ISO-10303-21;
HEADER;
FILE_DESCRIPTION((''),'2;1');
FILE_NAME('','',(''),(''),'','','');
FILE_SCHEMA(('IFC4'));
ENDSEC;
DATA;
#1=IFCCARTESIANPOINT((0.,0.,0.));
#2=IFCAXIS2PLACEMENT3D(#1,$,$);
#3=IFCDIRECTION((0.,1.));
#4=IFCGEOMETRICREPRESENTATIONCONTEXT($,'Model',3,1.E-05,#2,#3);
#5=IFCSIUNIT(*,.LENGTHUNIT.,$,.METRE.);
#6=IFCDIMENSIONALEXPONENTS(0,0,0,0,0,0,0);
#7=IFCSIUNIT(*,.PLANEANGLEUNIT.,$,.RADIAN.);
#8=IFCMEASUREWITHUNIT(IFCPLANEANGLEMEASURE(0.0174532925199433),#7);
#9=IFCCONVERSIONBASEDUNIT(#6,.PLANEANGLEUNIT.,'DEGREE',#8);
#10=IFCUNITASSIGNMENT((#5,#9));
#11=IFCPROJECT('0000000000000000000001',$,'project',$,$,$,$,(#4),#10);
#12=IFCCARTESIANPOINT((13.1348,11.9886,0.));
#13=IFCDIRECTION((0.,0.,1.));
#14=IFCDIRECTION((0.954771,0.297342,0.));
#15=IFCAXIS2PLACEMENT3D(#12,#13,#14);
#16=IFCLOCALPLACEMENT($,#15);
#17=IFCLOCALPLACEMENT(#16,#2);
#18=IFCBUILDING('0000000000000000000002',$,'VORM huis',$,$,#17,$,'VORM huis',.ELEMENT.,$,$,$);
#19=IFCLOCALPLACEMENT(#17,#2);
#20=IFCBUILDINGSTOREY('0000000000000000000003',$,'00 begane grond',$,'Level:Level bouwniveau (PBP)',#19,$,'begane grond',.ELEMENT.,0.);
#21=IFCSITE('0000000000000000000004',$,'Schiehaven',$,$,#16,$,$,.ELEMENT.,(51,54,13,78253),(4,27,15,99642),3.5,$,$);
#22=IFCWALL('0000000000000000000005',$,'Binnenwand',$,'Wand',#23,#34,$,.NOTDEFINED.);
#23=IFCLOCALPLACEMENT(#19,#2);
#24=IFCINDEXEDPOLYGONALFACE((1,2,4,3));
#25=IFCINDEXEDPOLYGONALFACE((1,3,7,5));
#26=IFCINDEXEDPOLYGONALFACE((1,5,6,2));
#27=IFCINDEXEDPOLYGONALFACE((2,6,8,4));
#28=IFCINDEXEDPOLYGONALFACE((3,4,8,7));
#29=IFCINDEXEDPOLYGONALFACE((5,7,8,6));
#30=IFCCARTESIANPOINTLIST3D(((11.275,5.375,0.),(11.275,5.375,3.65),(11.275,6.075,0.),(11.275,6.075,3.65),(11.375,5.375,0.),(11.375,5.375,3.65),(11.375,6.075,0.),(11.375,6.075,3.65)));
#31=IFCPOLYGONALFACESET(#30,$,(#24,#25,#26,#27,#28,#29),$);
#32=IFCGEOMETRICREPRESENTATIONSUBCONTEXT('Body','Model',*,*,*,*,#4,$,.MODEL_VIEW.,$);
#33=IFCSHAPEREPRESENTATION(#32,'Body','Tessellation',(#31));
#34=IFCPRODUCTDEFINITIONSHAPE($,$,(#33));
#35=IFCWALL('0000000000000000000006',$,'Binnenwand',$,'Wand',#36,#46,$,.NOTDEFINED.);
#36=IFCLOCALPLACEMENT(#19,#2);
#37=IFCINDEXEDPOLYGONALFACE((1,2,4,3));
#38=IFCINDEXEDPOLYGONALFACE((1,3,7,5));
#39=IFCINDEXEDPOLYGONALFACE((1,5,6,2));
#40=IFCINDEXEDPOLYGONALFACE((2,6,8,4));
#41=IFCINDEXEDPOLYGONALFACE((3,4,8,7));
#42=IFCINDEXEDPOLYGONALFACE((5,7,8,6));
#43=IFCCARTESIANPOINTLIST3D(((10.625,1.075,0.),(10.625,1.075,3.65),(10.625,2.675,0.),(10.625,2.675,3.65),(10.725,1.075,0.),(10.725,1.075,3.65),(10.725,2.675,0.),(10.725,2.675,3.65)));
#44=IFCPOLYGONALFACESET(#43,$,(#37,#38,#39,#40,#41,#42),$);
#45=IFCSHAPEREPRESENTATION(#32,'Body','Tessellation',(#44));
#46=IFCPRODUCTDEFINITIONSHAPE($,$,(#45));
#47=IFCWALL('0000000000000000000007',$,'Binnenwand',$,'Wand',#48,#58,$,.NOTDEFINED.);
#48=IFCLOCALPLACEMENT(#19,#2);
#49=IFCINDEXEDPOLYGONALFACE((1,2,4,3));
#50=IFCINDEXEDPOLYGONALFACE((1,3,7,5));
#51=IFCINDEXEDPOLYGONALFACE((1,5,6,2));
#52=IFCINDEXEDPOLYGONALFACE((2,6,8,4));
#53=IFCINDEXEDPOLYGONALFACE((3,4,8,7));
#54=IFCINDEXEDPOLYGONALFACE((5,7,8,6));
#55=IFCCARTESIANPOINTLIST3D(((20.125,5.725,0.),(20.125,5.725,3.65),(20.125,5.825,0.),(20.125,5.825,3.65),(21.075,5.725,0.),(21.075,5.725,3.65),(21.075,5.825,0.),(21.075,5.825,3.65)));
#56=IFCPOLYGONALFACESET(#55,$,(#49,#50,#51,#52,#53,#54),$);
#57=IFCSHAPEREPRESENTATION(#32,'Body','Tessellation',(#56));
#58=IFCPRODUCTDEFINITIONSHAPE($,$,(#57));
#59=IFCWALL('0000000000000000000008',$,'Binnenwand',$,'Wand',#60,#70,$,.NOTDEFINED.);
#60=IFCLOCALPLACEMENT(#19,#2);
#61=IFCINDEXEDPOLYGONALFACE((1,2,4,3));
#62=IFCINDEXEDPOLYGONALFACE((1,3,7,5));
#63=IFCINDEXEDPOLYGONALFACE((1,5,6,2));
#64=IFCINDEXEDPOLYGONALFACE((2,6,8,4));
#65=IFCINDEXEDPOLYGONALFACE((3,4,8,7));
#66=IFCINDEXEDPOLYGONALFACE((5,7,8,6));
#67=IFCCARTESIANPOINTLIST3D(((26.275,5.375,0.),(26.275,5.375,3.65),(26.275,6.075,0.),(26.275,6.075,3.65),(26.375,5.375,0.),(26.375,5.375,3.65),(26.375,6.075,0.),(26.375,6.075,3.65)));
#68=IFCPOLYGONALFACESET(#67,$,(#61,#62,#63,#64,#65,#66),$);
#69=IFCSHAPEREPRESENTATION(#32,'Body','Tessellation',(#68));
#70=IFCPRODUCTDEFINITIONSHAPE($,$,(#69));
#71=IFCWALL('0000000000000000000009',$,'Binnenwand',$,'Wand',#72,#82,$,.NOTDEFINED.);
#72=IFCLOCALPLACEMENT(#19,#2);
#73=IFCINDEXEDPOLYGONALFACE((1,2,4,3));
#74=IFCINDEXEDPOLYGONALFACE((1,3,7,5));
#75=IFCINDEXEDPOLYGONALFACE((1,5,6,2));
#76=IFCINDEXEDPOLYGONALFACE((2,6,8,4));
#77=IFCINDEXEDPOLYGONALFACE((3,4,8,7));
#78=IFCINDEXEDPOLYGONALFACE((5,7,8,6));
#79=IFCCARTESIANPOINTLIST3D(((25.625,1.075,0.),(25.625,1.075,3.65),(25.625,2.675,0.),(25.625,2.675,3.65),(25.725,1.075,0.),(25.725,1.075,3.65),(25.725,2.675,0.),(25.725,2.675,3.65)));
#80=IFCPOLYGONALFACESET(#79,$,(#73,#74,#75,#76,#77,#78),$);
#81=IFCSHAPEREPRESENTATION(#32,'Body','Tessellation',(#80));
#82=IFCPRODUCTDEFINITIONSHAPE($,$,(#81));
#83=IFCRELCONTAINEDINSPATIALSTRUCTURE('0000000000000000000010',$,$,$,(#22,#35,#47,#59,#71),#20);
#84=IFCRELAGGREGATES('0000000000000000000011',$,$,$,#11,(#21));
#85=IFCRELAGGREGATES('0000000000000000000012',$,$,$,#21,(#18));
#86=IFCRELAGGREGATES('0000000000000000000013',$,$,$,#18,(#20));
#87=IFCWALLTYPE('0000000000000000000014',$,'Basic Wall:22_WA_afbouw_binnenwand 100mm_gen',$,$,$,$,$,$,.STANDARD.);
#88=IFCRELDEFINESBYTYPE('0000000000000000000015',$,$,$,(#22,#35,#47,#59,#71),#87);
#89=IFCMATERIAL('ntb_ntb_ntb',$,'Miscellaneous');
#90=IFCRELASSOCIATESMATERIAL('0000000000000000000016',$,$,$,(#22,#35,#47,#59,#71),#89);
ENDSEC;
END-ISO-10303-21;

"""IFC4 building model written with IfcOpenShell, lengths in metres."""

from ifc_helpers import new_model, entity, si_unit, converted_unit, direction, frame, origin, place, context, subcontext, project, spatial, indexed_curve, outline, extrude, material, type_object, element, save


model = new_model("IFC4")

# Units and contexts
model_context = context("Model", 3, precision=1e-05, world=origin(), true_north=direction((0.0, 1.0)))
body_context = subcontext(model_context, "Body", "Model", "MODEL_VIEW")
ifc_project = project(units=[si_unit("LENGTHUNIT", "METRE"), converted_unit("PLANEANGLEUNIT", "DEGREE", entity("IfcPlaneAngleMeasure", 0.0174532925199433), si_unit("PLANEANGLEUNIT", "RADIAN"), dimensions=[0, 0, 0, 0, 0, 0, 0])], contexts=[model_context])

# Site, building, storey
site_placement = place(None, frame((13.1348, 11.9886, 0.0), z_axis=(0.0, 0.0, 1.0), x_axis=(0.954771, 0.297342, 0.0)))
site = spatial("IfcSite", under=ifc_project, at=site_placement, Name="Schiehaven", CompositionType="ELEMENT", RefLatitude=(51, 54, 13, 78253), RefLongitude=(4, 27, 15, 99642), RefElevation=3.5)
building_placement = place(site_placement, origin())
building = spatial("IfcBuilding", under=site, at=building_placement, Name="VORM huis", LongName="VORM huis", CompositionType="ELEMENT")
storey_placement = place(building_placement, origin())
storey = spatial("IfcBuildingStorey", under=building, at=storey_placement, Name="00 begane grond", ObjectType="Level:Level bouwniveau (PBP)", LongName="begane grond", CompositionType="ELEMENT", Elevation=0.0)

# Walls
ifc_material_1 = material(Name="ntb_ntb_ntb", Category="Miscellaneous")
wall_type_1 = type_object("IfcWallType", Name="Basic Wall:22_WA_afbouw_binnenwand 100mm_gen", PredefinedType="STANDARD")
wall_1_placement = place(storey_placement, frame((11.325, 6.075, 0.0), z_axis=(0.0, 0.0, 1.0), x_axis=(0.0, -1.0, 0.0)))
element("IfcWall", 1, at=wall_1_placement, inside=storey, type_object=wall_type_1, material=ifc_material_1, Name="Binnenwand", ObjectType="Wand", PredefinedType="NOTDEFINED", context=body_context, shape_type="SweptSolid", body=[
    extrude(outline(indexed_curve([(0.7, 0.05), (0.0, 0.05), (0.0, -0.05), (0.7, -0.05), (0.7, 0.05)], self_intersect=False)), origin(), (0.0, 0.0, 1.0), 3.65),
])
wall_2_placement = place(storey_placement, frame((10.675, 2.675, 0.0), z_axis=(0.0, 0.0, 1.0), x_axis=(0.0, -1.0, 0.0)))
element("IfcWall", 2, at=wall_2_placement, inside=storey, type_object=wall_type_1, material=ifc_material_1, Name="Binnenwand", ObjectType="Wand", PredefinedType="NOTDEFINED", context=body_context, shape_type="SweptSolid", body=[
    extrude(outline(indexed_curve([(1.6, 0.05), (0.0, 0.05), (0.0, -0.05), (1.6, -0.05), (1.6, 0.05)], self_intersect=False)), origin(), (0.0, 0.0, 1.0), 3.65),
])
wall_3_placement = place(storey_placement, frame((20.125, 5.775, 0.0)))
element("IfcWall", 3, at=wall_3_placement, inside=storey, type_object=wall_type_1, material=ifc_material_1, Name="Binnenwand", ObjectType="Wand", PredefinedType="NOTDEFINED", context=body_context, shape_type="SweptSolid", body=[
    extrude(outline(indexed_curve([(0.95, 0.05), (0.0, 0.05), (0.0, -0.05), (0.95, -0.05), (0.95, 0.05)], self_intersect=False)), origin(), (0.0, 0.0, 1.0), 3.65),
])
wall_4_placement = place(storey_placement, frame((26.325, 6.075, 0.0), z_axis=(0.0, 0.0, 1.0), x_axis=(0.0, -1.0, 0.0)))
element("IfcWall", 4, at=wall_4_placement, inside=storey, type_object=wall_type_1, material=ifc_material_1, Name="Binnenwand", ObjectType="Wand", PredefinedType="NOTDEFINED", context=body_context, shape_type="SweptSolid", body=[
    extrude(outline(indexed_curve([(0.7, 0.05), (0.0, 0.05), (0.0, -0.05), (0.7, -0.05), (0.7, 0.05)], self_intersect=False)), origin(), (0.0, 0.0, 1.0), 3.65),
])
wall_5_placement = place(storey_placement, frame((25.675, 2.675, 0.0), z_axis=(0.0, 0.0, 1.0), x_axis=(0.0, -1.0, 0.0)))
element("IfcWall", 5, at=wall_5_placement, inside=storey, type_object=wall_type_1, material=ifc_material_1, Name="Binnenwand", ObjectType="Wand", PredefinedType="NOTDEFINED", context=body_context, shape_type="SweptSolid", body=[
    extrude(outline(indexed_curve([(1.6, 0.05), (0.0, 0.05), (0.0, -0.05), (1.6, -0.05), (1.6, 0.05)], self_intersect=False)), origin(), (0.0, 0.0, 1.0), 3.65),
])

save(model, "model.ifc")
